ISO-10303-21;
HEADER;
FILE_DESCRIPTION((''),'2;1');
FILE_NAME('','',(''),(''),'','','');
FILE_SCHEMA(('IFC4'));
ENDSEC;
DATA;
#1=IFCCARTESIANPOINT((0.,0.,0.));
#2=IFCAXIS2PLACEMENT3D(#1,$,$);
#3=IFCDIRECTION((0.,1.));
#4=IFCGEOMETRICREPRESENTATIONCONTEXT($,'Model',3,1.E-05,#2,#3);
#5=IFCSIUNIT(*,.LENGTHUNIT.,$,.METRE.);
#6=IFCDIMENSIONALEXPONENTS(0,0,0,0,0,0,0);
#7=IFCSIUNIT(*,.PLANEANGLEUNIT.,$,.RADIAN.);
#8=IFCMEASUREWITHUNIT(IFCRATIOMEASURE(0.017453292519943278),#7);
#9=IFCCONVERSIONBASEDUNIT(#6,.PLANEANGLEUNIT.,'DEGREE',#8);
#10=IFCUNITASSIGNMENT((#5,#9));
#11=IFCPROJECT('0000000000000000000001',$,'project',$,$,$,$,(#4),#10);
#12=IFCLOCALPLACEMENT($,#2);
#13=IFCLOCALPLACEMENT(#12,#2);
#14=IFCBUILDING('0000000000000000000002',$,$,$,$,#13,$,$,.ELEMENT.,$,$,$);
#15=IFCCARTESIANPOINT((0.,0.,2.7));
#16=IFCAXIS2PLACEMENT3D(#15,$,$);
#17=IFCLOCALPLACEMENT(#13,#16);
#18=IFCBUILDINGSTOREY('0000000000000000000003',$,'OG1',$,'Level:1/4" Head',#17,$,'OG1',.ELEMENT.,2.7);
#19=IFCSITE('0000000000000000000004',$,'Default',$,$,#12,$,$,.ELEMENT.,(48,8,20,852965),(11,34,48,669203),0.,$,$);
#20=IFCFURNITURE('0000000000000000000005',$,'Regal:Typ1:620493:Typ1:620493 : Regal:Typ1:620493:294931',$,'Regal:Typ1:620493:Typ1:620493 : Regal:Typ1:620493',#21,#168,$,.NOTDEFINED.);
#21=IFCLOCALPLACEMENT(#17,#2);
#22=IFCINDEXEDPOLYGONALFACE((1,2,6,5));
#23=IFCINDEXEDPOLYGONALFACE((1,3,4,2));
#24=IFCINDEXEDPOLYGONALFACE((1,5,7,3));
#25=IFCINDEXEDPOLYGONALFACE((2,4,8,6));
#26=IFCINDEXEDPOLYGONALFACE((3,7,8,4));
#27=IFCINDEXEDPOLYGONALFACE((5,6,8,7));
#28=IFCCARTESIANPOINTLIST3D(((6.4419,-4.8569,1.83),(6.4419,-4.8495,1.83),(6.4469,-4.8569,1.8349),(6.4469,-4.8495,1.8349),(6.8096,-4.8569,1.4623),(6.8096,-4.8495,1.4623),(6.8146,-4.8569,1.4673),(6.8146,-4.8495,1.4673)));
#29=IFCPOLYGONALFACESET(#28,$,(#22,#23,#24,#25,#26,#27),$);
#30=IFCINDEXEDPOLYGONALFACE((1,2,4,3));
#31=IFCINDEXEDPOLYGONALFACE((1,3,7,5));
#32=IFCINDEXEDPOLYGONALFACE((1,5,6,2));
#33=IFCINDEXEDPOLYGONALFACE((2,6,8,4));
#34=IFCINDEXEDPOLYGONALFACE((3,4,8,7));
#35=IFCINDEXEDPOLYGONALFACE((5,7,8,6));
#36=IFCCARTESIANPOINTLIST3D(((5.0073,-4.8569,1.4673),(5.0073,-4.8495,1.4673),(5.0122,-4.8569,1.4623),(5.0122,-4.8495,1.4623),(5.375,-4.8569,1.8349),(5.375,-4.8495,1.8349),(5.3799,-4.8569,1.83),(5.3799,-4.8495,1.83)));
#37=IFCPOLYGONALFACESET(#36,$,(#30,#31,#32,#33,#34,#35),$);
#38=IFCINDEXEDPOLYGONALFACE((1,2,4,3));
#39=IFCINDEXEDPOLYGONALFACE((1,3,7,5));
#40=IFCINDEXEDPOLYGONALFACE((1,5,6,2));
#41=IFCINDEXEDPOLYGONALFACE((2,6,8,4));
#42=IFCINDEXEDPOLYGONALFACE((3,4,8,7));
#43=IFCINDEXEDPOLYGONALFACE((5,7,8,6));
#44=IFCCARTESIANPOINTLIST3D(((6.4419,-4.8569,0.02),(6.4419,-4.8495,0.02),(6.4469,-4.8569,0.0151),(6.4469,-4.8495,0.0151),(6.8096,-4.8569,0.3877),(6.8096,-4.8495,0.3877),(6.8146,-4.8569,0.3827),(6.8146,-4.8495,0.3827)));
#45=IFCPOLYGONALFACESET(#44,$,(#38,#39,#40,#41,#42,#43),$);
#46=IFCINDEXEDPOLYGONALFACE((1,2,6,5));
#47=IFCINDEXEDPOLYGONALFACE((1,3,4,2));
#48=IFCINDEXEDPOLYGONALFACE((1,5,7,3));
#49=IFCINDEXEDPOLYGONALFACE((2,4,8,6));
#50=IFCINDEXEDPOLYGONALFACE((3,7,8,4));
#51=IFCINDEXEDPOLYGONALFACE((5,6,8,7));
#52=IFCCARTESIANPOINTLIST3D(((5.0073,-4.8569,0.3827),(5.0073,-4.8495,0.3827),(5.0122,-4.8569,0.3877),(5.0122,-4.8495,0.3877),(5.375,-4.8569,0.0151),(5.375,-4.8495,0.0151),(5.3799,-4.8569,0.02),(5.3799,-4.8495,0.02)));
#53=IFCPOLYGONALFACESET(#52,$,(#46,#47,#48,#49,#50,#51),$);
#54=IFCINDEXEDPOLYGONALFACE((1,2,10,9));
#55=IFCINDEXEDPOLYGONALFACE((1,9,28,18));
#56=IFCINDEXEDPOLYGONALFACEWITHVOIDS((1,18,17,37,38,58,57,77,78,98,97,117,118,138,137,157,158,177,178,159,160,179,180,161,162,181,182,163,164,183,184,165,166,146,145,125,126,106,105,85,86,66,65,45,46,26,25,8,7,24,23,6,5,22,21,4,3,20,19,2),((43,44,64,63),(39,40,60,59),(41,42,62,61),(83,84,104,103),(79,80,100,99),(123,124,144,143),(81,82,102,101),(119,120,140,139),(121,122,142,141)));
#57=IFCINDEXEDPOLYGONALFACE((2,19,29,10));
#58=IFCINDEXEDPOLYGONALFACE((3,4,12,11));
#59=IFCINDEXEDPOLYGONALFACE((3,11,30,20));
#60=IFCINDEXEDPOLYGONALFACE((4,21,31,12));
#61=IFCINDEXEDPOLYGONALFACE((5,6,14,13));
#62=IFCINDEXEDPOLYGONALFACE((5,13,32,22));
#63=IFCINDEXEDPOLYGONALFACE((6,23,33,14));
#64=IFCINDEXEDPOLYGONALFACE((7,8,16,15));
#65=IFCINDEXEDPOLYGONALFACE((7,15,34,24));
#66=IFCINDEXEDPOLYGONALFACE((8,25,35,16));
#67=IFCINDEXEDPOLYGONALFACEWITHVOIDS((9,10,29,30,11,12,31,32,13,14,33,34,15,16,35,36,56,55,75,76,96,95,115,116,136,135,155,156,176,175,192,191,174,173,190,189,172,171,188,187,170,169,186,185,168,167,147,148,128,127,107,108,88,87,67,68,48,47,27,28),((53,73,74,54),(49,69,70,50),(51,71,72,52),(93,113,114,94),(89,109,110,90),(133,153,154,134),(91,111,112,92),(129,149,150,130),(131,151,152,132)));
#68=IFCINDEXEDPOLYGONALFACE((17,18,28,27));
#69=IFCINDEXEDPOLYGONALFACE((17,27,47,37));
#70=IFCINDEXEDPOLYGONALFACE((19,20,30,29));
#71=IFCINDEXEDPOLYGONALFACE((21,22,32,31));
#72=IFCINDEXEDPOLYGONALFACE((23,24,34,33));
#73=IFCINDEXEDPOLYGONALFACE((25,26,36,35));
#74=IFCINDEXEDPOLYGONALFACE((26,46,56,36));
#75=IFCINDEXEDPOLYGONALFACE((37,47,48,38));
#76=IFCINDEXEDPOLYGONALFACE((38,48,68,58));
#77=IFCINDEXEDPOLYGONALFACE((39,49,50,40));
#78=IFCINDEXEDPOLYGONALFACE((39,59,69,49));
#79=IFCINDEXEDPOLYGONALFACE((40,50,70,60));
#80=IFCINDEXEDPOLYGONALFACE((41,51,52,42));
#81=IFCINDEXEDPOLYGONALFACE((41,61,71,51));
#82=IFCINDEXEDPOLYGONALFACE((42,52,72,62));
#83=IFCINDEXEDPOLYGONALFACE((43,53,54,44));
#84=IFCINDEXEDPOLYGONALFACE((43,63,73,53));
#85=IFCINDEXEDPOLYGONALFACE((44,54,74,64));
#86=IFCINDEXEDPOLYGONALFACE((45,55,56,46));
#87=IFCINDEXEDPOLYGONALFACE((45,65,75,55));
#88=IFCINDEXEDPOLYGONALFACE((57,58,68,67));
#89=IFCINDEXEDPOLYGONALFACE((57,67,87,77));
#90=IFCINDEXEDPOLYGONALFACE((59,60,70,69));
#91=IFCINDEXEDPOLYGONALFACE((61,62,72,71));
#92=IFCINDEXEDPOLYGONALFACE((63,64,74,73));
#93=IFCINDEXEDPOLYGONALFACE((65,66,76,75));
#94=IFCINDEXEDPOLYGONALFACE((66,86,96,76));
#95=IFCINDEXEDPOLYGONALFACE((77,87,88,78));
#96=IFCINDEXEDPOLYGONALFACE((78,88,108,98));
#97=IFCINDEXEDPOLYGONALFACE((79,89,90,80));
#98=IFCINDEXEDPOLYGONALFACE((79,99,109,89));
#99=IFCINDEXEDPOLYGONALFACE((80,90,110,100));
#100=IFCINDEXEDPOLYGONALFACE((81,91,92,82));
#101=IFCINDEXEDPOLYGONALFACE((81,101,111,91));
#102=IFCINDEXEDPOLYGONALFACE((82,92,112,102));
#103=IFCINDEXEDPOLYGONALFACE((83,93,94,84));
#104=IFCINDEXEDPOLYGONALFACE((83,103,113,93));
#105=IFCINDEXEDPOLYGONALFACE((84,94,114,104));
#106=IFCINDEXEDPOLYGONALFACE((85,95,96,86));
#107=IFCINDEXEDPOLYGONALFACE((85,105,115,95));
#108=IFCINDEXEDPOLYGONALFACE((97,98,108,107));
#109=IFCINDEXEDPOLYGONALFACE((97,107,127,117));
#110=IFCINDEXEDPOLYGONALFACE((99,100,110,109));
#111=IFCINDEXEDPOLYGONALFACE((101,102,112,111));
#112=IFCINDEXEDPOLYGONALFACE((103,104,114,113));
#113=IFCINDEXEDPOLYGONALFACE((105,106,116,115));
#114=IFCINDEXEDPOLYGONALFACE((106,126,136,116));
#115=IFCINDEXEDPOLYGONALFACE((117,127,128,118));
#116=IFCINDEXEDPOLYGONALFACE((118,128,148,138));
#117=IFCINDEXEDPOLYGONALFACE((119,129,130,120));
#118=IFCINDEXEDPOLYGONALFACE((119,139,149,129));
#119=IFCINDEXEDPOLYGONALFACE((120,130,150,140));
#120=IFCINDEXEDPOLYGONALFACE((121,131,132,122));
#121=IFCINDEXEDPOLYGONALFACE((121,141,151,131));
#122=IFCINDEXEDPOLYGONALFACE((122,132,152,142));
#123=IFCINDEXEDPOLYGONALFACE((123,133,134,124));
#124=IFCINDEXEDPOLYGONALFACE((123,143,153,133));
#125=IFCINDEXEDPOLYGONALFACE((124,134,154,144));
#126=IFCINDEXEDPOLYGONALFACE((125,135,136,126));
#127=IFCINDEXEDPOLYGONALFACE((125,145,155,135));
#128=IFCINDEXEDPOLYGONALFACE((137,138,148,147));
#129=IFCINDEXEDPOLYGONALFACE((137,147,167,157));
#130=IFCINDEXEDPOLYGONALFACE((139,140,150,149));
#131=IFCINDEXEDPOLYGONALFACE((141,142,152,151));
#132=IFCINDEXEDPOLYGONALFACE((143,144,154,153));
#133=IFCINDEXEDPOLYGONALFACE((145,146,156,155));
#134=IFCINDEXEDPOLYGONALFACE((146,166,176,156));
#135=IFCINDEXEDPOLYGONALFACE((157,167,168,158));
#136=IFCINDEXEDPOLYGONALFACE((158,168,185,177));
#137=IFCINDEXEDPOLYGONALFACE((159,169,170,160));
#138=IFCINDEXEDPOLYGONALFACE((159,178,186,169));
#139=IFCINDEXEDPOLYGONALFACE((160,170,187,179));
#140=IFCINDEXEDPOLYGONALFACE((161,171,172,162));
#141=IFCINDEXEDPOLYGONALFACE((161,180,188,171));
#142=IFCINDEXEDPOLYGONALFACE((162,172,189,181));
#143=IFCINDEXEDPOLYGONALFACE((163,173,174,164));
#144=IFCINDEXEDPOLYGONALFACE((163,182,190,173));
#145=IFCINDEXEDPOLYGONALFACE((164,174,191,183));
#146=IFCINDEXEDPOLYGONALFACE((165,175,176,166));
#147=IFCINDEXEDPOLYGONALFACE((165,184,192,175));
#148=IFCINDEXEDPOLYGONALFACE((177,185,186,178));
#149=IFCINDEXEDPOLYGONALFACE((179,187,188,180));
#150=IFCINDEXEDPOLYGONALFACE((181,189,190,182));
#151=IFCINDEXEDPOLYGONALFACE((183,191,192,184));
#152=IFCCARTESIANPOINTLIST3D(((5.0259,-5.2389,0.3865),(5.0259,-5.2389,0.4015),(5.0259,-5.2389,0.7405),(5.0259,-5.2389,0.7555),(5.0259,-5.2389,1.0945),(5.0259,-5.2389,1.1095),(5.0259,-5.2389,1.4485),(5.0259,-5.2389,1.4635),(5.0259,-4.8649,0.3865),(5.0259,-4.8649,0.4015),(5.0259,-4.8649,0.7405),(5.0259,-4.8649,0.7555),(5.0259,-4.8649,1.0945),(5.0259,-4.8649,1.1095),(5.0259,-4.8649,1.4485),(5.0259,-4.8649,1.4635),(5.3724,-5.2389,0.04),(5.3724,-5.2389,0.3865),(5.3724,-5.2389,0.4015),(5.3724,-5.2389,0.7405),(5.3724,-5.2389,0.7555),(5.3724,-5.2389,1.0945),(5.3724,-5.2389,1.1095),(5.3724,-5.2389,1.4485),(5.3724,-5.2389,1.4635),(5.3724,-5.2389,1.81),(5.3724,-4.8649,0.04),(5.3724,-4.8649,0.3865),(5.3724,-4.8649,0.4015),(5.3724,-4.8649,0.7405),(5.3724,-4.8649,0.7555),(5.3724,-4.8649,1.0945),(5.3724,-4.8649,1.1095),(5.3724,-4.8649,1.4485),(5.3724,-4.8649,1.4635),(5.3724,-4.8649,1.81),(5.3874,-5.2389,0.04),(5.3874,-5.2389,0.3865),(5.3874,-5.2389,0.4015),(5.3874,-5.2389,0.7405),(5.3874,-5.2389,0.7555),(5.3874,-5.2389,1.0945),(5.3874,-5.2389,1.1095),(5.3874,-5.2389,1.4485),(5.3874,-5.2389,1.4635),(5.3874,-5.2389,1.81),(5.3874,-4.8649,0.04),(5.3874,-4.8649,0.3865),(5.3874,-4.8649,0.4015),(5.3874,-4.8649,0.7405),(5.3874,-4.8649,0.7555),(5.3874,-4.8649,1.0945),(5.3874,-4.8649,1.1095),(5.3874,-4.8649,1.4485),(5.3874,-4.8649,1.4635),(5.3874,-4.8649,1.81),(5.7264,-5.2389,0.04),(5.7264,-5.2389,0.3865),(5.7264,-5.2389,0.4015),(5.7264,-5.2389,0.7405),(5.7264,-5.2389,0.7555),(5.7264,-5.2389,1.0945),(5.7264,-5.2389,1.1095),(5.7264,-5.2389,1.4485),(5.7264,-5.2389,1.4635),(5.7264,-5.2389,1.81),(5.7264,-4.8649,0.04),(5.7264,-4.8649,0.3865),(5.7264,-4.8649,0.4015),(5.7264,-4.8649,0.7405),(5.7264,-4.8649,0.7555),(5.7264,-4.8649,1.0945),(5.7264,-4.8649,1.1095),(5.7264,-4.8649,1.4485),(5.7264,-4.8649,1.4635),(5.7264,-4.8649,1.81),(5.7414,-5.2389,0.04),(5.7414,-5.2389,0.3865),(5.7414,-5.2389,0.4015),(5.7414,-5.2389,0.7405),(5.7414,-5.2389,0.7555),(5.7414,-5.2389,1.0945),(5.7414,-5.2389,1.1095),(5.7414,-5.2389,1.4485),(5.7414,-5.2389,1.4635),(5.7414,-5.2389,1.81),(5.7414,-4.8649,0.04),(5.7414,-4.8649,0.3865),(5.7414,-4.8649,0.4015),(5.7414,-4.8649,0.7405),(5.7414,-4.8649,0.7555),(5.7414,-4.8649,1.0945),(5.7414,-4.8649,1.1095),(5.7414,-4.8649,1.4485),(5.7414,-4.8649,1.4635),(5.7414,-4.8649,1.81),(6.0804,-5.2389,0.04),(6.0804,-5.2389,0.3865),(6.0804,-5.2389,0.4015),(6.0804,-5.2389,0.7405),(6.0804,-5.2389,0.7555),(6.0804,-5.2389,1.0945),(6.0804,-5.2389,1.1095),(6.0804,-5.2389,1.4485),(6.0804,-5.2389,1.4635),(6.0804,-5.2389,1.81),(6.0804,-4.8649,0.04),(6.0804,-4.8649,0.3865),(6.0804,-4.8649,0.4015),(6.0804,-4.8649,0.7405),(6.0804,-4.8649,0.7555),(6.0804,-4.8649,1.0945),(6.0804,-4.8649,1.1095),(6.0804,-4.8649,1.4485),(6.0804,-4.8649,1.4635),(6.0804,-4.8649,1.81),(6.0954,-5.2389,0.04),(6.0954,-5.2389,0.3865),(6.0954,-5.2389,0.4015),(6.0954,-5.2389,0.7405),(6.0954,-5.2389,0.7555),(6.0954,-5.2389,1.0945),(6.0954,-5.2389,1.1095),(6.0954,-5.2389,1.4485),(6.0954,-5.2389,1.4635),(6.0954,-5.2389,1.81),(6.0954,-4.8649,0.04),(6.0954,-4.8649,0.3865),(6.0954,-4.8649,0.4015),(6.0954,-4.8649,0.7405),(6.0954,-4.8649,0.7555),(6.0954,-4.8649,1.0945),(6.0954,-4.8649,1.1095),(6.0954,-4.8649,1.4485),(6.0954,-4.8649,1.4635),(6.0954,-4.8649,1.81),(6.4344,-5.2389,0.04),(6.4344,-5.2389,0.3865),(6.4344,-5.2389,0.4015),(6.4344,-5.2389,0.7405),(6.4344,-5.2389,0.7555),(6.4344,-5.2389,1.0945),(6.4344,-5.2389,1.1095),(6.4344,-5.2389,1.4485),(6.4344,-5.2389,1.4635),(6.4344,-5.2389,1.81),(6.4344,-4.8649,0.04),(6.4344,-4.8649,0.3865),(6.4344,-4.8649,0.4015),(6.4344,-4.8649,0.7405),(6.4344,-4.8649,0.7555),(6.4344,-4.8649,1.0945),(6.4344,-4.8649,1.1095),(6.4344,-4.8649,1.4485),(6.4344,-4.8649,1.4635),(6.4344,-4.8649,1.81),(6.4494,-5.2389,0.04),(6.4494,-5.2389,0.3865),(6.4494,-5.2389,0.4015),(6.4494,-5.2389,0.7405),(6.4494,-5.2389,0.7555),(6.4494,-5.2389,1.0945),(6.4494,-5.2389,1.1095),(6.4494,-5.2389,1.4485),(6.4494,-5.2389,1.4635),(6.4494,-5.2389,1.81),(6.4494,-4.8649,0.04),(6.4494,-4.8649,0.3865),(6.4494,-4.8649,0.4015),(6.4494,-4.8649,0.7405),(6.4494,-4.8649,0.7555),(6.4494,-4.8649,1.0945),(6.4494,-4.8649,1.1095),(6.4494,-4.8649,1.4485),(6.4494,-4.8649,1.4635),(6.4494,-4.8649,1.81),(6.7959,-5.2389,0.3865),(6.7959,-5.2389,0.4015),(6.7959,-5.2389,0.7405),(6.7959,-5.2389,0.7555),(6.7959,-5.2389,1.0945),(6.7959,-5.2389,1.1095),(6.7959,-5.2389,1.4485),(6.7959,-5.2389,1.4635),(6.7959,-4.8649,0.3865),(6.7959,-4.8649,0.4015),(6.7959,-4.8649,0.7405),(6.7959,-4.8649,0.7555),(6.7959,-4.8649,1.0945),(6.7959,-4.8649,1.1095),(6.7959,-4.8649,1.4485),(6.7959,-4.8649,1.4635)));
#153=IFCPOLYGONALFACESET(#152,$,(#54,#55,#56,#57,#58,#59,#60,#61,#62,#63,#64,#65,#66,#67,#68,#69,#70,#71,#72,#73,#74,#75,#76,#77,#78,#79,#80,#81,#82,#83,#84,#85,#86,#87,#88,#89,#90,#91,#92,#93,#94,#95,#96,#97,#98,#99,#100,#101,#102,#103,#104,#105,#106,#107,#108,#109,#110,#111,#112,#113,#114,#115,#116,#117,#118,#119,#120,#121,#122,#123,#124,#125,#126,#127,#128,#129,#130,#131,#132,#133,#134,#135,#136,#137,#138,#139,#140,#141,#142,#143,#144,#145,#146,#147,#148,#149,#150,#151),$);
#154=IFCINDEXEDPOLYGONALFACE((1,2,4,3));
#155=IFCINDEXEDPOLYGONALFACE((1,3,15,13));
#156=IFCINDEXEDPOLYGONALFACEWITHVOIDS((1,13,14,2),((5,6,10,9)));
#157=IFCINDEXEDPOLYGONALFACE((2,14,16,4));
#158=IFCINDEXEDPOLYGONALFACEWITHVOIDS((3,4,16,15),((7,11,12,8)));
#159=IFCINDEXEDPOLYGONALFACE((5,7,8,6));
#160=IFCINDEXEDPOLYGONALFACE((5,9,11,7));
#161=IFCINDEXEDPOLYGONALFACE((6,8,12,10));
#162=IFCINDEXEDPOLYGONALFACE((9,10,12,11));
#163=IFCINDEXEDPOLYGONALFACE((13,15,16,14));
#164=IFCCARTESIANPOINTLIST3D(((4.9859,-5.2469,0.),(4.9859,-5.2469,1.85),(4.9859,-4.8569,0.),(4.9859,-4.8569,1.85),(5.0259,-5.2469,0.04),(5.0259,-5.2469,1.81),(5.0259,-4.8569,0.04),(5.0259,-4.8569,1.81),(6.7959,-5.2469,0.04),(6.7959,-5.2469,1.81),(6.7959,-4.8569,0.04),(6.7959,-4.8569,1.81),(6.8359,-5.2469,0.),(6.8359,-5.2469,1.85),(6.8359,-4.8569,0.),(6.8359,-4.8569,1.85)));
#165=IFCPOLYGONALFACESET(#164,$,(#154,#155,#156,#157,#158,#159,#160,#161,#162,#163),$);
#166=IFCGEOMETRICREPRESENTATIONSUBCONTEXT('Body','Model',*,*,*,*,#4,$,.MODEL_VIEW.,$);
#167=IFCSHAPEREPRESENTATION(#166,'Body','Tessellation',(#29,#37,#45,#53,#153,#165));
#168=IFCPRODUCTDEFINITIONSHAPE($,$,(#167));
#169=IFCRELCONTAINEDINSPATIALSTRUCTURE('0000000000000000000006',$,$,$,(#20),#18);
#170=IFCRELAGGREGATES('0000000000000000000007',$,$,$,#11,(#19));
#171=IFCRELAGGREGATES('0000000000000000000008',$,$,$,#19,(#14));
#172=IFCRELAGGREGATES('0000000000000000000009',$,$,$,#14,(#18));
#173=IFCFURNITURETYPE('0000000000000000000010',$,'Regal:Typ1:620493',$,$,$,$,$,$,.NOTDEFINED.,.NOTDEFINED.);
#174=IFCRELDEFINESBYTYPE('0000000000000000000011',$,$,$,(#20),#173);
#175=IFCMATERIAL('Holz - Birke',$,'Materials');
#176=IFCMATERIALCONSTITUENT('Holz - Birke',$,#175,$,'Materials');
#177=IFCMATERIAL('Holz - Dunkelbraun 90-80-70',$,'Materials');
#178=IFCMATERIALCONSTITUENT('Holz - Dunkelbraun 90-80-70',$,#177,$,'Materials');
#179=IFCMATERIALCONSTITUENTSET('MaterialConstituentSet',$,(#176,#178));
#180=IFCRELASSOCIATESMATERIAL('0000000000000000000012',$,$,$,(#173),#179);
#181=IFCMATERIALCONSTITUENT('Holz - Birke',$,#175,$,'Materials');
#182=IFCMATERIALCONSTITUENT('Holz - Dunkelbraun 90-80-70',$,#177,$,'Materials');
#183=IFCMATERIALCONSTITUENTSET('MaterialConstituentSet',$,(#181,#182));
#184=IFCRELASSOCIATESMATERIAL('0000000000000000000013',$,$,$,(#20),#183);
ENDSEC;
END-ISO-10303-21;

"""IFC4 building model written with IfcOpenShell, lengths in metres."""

from ifc_helpers import new_model, entity, si_unit, converted_unit, direction, frame, origin, place, context, subcontext, project, spatial, indexed_curve, outline, extrude, source, transform, mapped, material, constituent, constituent_set, type_object, type_shapes, element, save


model = new_model("IFC4")

# Units and contexts
model_context = context("Model", 3, precision=1e-05, world=origin(), true_north=direction((0.0, 1.0)))
body_context = subcontext(model_context, "Body", "Model", "MODEL_VIEW")
ifc_project = project(units=[si_unit("LENGTHUNIT", "METRE"), converted_unit("PLANEANGLEUNIT", "DEGREE", entity("IfcRatioMeasure", 0.017453292519943278), si_unit("PLANEANGLEUNIT", "RADIAN"), dimensions=[0, 0, 0, 0, 0, 0, 0])], contexts=[model_context])

# Site, building, storey
site_placement = place(None, origin())
site = spatial("IfcSite", under=ifc_project, at=site_placement, Name="Default", CompositionType="ELEMENT", RefLatitude=(48, 8, 20, 852965), RefLongitude=(11, 34, 48, 669203), RefElevation=0.0)
building_placement = place(site_placement, origin())
building = spatial("IfcBuilding", under=site, at=building_placement, CompositionType="ELEMENT")
storey_placement = place(building_placement, frame((0.0, 0.0, 2.7)))
storey = spatial("IfcBuildingStorey", under=building, at=storey_placement, Name="OG1", ObjectType="Level:1/4\" Head", LongName="OG1", CompositionType="ELEMENT", Elevation=2.7)

# Shared definitions
ifc_material_1 = material(Name="Holz - Birke", Category="Materials")

# Furniture
ifc_material_2 = material(Name="Holz - Dunkelbraun 90-80-70", Category="Materials")
ifc_constituent_1 = constituent(ifc_material_1, Name="Holz - Birke", Category="Materials")
ifc_constituent_2 = constituent(ifc_material_2, Name="Holz - Dunkelbraun 90-80-70", Category="Materials")
ifc_constituent_set_1 = constituent_set(constituents=[ifc_constituent_1, ifc_constituent_2], Name="MaterialConstituentSet")
ifc_constituent_3 = constituent(ifc_material_1, Name="Holz - Birke", Category="Materials")
ifc_constituent_4 = constituent(ifc_material_2, Name="Holz - Dunkelbraun 90-80-70", Category="Materials")
ifc_constituent_set_2 = constituent_set(constituents=[ifc_constituent_3, ifc_constituent_4], Name="MaterialConstituentSet")
furniture_type_1 = type_object("IfcFurnitureType", Name="Regal:Typ1:620493", AssemblyPlace="NOTDEFINED", PredefinedType="NOTDEFINED", material=ifc_constituent_set_2)
shared_shape_1 = source(origin(), body_context, "Body", "SweptSolid", [
    extrude(outline(indexed_curve([(-0.0035, -0.0037), (0.0035, -0.0037), (0.0035, 0.0037), (-0.0035, 0.0037), (-0.0035, -0.0037)], self_intersect=False)), frame((6.8121, -4.8532, 4.1648), z_axis=(-0.707107, 0.0, 0.707107), x_axis=(-0.707107, 0.0, -0.707107)), (0.0, 0.0, 1.0), 0.52),
    extrude(outline(indexed_curve([(-0.0035, -0.0037), (0.0035, -0.0037), (0.0035, 0.0037), (-0.0035, 0.0037), (-0.0035, -0.0037)], self_intersect=False)), frame((5.0098, -4.8532, 4.1648), z_axis=(0.707107, 0.0, 0.707107), x_axis=(-0.707107, 0.0, 0.707107)), (0.0, 0.0, 1.0), 0.52),
    extrude(outline(indexed_curve([(-0.0035, -0.0037), (0.0035, -0.0037), (0.0035, 0.0037), (-0.0035, 0.0037), (-0.0035, -0.0037)], self_intersect=False)), frame((6.4444, -4.8532, 2.7175), z_axis=(0.707107, 0.0, 0.707107), x_axis=(-0.707107, 0.0, 0.707107)), (0.0, 0.0, 1.0), 0.52),
    extrude(outline(indexed_curve([(-0.0035, -0.0037), (0.0035, -0.0037), (0.0035, 0.0037), (-0.0035, 0.0037), (-0.0035, -0.0037)], self_intersect=False)), frame((5.3775, -4.8532, 2.7175), z_axis=(-0.707107, 0.0, 0.707107), x_axis=(-0.707107, 0.0, -0.707107)), (0.0, 0.0, 1.0), 0.52),
    extrude(outline(indexed_curve([(-0.5385, -0.885), (-0.5235, -0.885), (-0.5235, -0.5385), (-0.1845, -0.5385), (-0.1845, -0.885), (-0.1695, -0.885), (-0.1695, -0.5385), (0.1695, -0.5385), (0.1695, -0.885), (0.1845, -0.885), (0.1845, -0.5385), (0.5235, -0.5385), (0.5235, -0.885), (0.5385, -0.885), (0.5385, -0.5385), (0.885, -0.5385), (0.885, -0.5235), (0.5385, -0.5235), (0.5385, -0.1845), (0.885, -0.1845), (0.885, -0.1695), (0.5385, -0.1695), (0.5385, 0.1695), (0.885, 0.1695), (0.885, 0.1845), (0.5385, 0.1845), (0.5385, 0.5235), (0.885, 0.5235), (0.885, 0.5385), (0.5385, 0.5385), (0.5385, 0.885), (0.5235, 0.885), (0.5235, 0.5385), (0.1845, 0.5385), (0.1845, 0.885), (0.1695, 0.885), (0.1695, 0.5385), (-0.1695, 0.5385), (-0.1695, 0.885), (-0.1845, 0.885), (-0.1845, 0.5385), (-0.5235, 0.5385), (-0.5235, 0.885), (-0.5385, 0.885), (-0.5385, 0.5385), (-0.885, 0.5385), (-0.885, 0.5235), (-0.5385, 0.5235), (-0.5385, 0.1845), (-0.885, 0.1845), (-0.885, 0.1695), (-0.5385, 0.1695), (-0.5385, -0.1695), (-0.885, -0.1695), (-0.885, -0.1845), (-0.5385, -0.1845), (-0.5385, -0.5235), (-0.885, -0.5235), (-0.885, -0.5385), (-0.5385, -0.5385), (-0.5385, -0.885)], self_intersect=False), holes=[indexed_curve([(-0.5235, -0.5235), (-0.5235, -0.1845), (-0.1845, -0.1845), (-0.1845, -0.5235), (-0.5235, -0.5235)], self_intersect=False), indexed_curve([(0.1695, -0.1845), (0.1695, -0.5235), (-0.1695, -0.5235), (-0.1695, -0.1845), (0.1695, -0.1845)], self_intersect=False), indexed_curve([(0.5235, -0.1845), (0.5235, -0.5235), (0.1845, -0.5235), (0.1845, -0.1845), (0.5235, -0.1845)], self_intersect=False), indexed_curve([(0.5235, -0.1695), (0.1845, -0.1695), (0.1845, 0.1695), (0.5235, 0.1695), (0.5235, -0.1695)], self_intersect=False), indexed_curve([(0.1695, -0.1695), (-0.1695, -0.1695), (-0.1695, 0.1695), (0.1695, 0.1695), (0.1695, -0.1695)], self_intersect=False), indexed_curve([(-0.1845, -0.1695), (-0.5235, -0.1695), (-0.5235, 0.1695), (-0.1845, 0.1695), (-0.1845, -0.1695)], self_intersect=False), indexed_curve([(-0.1845, 0.5235), (-0.1845, 0.1845), (-0.5235, 0.1845), (-0.5235, 0.5235), (-0.1845, 0.5235)], self_intersect=False), indexed_curve([(0.1695, 0.5235), (0.1695, 0.1845), (-0.1695, 0.1845), (-0.1695, 0.5235), (0.1695, 0.5235)], self_intersect=False), indexed_curve([(0.5235, 0.5235), (0.5235, 0.1845), (0.1845, 0.1845), (0.1845, 0.5235), (0.5235, 0.5235)], self_intersect=False)]), frame((5.9109, -5.2389, 3.625), z_axis=(0.0, 1.0, 0.0), x_axis=(1.0, 0.0, 0.0)), (0.0, 0.0, 1.0), 0.374),
    extrude(outline(indexed_curve([(-0.925, -0.925), (0.925, -0.925), (0.925, 0.925), (-0.925, 0.925), (-0.925, -0.925)], self_intersect=False), holes=[indexed_curve([(0.885, 0.885), (0.885, -0.885), (-0.885, -0.885), (-0.885, 0.885), (0.885, 0.885)], self_intersect=False)]), frame((5.9109, -5.2469, 3.625), z_axis=(0.0, 1.0, 0.0), x_axis=(-1.0, 0.0, 0.0)), (0.0, 0.0, 1.0), 0.39),
])
type_shapes(furniture_type_1, [shared_shape_1])
furniture_1_placement = place(storey_placement, frame((0.0, 0.0, -2.7)))
element("IfcFurniture", 1, at=furniture_1_placement, inside=storey, type_object=furniture_type_1, material=ifc_constituent_set_1, Name="Regal:Typ1:620493:Typ1:620493 : Regal:Typ1:620493:294931", ObjectType="Regal:Typ1:620493:Typ1:620493 : Regal:Typ1:620493", PredefinedType="NOTDEFINED", context=body_context, shape_type="MappedRepresentation", body=[
    mapped(shared_shape_1, transform((0.0, 0.0, 0.0), scale=1.0)),
])

save(model, "model.ifc")
